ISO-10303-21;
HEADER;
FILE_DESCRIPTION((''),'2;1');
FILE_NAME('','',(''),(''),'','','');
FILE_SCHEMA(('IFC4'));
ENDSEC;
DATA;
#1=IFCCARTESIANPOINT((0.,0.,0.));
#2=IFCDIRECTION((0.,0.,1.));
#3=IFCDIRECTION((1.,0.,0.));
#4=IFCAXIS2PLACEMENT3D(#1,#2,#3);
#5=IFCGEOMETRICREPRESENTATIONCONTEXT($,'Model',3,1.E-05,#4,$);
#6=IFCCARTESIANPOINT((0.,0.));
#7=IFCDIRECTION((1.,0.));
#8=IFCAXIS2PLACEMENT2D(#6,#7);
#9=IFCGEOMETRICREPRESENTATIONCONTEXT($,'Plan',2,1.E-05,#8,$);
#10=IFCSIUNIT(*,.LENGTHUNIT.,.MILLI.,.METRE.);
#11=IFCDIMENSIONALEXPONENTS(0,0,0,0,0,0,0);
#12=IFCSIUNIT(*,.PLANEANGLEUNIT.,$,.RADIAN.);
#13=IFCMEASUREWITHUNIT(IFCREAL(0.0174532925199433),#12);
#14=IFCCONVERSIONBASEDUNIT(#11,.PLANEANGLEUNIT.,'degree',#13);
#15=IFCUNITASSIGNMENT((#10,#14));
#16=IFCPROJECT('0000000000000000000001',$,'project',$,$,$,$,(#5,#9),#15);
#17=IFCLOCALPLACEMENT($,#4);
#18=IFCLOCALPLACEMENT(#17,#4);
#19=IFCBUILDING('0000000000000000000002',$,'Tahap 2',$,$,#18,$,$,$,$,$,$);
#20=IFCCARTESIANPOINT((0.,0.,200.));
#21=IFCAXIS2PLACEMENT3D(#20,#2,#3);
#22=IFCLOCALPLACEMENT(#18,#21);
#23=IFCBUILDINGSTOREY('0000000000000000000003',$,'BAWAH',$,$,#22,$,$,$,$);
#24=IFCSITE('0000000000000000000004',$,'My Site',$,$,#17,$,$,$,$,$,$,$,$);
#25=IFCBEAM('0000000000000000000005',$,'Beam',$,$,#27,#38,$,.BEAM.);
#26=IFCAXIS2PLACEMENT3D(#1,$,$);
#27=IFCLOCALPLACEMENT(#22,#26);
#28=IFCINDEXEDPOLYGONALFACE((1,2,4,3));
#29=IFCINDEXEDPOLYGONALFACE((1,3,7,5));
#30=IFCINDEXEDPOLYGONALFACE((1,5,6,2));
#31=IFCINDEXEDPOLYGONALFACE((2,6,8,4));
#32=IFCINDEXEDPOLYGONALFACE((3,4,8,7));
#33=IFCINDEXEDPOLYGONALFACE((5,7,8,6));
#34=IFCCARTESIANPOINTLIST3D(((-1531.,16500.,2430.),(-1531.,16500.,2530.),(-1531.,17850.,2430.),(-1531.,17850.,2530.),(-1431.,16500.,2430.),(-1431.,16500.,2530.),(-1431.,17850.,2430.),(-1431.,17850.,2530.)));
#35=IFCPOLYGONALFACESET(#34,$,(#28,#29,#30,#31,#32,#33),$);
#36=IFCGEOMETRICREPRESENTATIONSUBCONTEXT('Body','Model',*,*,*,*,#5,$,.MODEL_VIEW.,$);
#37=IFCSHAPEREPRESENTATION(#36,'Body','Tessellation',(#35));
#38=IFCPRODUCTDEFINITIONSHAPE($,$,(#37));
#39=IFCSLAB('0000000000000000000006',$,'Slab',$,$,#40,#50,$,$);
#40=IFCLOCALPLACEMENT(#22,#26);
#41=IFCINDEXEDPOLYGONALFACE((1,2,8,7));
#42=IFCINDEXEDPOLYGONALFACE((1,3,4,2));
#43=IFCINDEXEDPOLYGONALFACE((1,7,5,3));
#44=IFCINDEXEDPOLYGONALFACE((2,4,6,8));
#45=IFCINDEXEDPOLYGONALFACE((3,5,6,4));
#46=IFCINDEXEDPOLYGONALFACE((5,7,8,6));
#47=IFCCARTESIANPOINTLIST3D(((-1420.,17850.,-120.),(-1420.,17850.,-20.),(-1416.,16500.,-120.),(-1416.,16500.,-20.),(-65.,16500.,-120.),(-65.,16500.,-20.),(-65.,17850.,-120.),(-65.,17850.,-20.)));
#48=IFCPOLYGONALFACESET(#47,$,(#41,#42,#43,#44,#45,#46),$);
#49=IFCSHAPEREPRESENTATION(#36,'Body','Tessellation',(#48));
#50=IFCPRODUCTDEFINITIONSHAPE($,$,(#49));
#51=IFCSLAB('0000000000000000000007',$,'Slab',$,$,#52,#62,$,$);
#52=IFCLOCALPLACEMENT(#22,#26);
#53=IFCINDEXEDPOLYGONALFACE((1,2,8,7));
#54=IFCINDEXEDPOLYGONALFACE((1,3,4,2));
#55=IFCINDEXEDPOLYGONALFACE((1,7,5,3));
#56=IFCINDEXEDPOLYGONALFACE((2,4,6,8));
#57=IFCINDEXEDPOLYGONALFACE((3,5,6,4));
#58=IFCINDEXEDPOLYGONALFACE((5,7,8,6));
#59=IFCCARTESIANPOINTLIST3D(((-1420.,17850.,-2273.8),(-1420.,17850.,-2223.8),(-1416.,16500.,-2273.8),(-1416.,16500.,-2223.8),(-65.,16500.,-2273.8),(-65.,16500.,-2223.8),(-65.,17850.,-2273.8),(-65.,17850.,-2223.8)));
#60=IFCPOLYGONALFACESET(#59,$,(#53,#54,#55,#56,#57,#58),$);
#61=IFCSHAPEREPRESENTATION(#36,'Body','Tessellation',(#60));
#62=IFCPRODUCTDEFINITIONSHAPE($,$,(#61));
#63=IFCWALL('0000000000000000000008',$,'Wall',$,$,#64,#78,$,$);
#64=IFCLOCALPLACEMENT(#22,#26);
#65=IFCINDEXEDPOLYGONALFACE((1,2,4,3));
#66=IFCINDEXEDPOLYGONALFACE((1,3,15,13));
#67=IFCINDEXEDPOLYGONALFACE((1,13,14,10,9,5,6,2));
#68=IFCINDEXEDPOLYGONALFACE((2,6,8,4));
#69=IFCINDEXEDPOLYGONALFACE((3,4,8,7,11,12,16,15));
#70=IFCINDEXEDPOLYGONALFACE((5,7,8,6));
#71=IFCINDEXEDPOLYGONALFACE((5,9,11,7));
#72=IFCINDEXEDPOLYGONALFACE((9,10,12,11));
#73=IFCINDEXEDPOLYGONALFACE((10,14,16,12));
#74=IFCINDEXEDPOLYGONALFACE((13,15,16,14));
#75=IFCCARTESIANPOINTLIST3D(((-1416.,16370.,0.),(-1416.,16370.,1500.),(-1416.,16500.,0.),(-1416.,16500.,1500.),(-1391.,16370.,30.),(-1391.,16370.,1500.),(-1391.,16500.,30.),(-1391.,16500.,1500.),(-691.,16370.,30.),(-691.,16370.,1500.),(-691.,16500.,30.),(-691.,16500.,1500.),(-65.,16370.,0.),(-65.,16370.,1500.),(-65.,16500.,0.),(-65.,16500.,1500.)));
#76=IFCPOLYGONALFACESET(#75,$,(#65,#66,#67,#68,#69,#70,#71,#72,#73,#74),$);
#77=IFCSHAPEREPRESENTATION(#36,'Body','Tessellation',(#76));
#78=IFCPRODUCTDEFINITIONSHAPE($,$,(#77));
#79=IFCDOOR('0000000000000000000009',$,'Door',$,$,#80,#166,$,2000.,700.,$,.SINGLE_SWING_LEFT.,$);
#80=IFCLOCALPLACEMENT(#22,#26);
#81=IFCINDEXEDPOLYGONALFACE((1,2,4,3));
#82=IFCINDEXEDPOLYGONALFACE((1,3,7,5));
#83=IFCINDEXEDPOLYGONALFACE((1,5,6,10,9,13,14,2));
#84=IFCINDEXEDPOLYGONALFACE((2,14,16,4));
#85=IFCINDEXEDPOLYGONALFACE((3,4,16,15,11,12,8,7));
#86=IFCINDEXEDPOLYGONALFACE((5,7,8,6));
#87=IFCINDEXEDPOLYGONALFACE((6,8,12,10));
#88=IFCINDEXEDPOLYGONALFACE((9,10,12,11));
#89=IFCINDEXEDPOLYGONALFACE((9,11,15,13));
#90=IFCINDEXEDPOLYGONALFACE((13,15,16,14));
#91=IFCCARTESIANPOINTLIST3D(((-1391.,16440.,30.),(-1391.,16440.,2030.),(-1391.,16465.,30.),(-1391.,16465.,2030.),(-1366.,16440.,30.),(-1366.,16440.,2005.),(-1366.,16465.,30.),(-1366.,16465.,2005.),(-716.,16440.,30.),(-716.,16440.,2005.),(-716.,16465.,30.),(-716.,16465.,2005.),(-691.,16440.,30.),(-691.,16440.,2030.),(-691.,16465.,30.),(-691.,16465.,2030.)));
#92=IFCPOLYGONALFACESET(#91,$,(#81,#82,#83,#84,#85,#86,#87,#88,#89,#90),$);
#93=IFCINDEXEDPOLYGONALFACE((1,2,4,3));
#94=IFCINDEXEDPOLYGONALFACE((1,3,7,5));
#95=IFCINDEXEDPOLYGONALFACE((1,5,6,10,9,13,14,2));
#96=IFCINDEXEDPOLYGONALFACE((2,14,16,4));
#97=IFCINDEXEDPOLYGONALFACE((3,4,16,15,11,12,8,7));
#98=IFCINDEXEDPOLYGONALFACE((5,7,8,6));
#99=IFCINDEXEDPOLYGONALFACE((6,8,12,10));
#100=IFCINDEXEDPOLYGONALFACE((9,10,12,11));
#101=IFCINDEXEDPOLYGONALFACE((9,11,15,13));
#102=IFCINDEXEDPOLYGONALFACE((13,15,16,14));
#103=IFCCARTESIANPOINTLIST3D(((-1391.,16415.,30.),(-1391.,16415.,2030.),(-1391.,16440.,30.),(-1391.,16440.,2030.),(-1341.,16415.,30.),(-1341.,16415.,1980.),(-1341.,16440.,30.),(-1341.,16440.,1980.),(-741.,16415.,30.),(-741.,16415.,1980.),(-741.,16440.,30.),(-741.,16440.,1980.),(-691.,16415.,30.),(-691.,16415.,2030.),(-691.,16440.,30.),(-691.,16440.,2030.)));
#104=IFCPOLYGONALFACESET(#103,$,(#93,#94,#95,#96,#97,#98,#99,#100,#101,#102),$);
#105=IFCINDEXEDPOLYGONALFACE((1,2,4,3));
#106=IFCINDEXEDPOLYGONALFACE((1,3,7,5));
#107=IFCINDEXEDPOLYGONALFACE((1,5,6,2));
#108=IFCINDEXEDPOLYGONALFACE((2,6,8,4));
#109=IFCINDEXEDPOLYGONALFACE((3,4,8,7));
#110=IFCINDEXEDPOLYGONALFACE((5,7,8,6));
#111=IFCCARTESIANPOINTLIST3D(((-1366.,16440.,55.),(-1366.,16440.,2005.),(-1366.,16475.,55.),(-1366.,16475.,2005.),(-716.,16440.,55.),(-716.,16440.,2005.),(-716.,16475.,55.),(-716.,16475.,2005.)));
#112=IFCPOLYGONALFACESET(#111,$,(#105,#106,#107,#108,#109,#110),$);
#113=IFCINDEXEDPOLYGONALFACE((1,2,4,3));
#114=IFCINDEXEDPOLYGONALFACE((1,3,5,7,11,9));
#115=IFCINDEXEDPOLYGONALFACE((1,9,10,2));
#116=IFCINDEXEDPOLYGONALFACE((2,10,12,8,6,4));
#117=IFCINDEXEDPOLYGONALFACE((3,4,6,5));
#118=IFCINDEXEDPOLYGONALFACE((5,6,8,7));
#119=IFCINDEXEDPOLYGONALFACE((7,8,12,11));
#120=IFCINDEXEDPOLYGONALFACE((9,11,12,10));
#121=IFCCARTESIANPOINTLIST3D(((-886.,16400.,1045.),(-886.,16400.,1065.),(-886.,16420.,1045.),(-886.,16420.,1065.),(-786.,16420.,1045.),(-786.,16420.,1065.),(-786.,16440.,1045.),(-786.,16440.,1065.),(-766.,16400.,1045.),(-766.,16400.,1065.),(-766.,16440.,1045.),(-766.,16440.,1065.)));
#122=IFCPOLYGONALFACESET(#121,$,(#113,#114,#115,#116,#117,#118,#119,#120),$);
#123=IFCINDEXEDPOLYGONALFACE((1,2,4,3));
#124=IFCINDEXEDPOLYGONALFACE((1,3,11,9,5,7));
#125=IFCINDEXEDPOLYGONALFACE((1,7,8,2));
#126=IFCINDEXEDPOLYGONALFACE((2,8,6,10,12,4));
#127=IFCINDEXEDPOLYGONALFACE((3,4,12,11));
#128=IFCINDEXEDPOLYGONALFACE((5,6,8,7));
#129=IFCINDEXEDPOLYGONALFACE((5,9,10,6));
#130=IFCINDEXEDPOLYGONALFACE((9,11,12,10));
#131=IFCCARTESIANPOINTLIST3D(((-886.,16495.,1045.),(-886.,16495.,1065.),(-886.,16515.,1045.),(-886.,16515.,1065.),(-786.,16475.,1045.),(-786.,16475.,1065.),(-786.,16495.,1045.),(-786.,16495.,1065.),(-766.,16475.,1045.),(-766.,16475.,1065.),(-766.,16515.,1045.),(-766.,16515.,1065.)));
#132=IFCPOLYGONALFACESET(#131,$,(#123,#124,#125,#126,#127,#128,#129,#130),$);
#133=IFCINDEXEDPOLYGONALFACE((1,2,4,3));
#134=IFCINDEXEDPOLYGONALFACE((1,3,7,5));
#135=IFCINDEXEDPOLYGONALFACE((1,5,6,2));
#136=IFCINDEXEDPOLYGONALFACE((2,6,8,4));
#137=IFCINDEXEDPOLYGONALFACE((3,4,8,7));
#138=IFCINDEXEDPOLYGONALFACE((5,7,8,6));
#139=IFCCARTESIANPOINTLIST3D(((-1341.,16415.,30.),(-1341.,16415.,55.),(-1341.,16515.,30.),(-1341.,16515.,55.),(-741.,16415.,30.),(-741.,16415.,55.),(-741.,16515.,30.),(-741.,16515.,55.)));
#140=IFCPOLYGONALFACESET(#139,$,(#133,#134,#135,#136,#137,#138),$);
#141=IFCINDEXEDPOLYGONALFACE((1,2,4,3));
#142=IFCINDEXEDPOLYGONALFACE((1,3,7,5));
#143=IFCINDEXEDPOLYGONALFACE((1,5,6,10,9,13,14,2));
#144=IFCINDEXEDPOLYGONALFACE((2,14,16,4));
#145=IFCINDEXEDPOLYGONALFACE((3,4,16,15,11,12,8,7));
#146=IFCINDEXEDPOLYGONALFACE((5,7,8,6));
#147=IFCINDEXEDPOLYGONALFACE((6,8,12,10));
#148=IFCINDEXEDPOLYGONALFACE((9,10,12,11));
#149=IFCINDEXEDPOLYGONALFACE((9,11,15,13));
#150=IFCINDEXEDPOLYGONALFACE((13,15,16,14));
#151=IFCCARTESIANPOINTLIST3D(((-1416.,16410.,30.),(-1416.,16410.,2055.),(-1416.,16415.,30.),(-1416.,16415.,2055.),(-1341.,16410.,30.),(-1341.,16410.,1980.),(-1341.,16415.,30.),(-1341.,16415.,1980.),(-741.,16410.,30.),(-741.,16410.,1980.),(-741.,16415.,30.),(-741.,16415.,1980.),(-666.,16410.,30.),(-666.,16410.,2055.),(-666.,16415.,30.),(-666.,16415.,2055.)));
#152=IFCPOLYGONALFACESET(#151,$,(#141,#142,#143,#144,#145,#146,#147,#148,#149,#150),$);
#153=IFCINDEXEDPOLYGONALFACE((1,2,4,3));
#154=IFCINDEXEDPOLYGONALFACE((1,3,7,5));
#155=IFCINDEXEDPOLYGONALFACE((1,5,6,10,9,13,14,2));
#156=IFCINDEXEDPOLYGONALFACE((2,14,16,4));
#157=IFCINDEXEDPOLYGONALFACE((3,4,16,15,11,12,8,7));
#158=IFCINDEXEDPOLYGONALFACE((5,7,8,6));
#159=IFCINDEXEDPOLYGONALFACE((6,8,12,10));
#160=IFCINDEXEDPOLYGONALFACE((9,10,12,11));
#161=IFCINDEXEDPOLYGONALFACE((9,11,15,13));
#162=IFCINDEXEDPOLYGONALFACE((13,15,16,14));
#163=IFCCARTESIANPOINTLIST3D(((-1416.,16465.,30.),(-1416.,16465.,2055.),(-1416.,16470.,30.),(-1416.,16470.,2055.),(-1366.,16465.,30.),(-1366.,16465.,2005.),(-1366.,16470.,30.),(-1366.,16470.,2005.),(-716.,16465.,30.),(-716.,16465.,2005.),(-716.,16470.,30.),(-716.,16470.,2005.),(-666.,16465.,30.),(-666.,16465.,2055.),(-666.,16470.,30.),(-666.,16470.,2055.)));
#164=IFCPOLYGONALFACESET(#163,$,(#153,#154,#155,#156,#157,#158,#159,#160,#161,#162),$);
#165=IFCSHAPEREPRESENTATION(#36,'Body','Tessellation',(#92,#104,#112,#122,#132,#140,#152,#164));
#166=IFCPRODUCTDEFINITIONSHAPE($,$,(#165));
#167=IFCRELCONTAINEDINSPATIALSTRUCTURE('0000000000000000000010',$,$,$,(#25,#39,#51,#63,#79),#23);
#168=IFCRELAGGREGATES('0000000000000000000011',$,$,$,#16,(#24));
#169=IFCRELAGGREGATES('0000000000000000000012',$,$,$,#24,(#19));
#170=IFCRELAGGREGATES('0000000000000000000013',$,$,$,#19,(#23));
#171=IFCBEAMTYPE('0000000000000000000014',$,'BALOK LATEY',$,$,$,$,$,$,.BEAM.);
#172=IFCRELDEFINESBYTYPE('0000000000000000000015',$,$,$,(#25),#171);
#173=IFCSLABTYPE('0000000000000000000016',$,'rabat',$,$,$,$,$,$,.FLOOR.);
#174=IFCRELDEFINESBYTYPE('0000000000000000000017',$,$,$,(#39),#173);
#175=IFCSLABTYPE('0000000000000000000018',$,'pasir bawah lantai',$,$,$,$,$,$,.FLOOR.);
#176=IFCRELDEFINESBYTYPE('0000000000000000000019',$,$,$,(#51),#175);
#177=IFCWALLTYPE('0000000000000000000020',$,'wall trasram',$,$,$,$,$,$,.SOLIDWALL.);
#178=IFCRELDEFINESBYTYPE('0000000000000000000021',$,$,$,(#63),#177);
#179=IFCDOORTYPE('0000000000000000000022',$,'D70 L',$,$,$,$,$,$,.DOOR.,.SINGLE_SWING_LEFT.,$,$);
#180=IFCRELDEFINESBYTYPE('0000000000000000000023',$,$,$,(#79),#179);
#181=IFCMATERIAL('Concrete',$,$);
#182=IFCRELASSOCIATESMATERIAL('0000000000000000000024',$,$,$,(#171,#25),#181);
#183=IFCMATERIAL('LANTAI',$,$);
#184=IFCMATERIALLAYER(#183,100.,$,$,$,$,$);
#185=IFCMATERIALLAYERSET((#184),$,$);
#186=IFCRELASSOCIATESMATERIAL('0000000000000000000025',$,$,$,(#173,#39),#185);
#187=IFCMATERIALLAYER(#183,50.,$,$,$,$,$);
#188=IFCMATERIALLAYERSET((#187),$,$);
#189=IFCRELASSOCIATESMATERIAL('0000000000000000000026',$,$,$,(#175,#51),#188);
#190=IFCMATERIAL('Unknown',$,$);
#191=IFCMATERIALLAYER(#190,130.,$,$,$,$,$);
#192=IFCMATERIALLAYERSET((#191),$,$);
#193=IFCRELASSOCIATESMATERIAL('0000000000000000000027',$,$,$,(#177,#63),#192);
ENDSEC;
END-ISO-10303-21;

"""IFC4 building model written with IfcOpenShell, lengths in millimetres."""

from ifc_helpers import new_model, entity, si_unit, converted_unit, frame, origin_with_axes, origin_2d_with_axis, place, context, subcontext, project, spatial, line, indexed_curve, rectangle, outline, extrude, shape, source, transform, mapped, material, layer, layer_set, layer_usage, material_profile, profile_set, profile_usage, type_object, type_shapes, element, fill, save


model = new_model("IFC4")

# Units and contexts
model_context = context("Model", 3, precision=1e-05, world=origin_with_axes())
plan_context = context("Plan", 2, precision=1e-05, world=origin_2d_with_axis())
body_context_1 = subcontext(model_context, "Body", "Model", "MODEL_VIEW")
body_context_2 = subcontext(plan_context, "Body", "Plan", "PLAN_VIEW")
ifc_project = project(units=[si_unit("LENGTHUNIT", "METRE", prefix="MILLI"), converted_unit("PLANEANGLEUNIT", "degree", entity("IfcReal", 0.0174532925199433), si_unit("PLANEANGLEUNIT", "RADIAN"), dimensions=[0, 0, 0, 0, 0, 0, 0])], contexts=[model_context, plan_context])

# Site, building, storey
site_placement = place(None, origin_with_axes())
site = spatial("IfcSite", under=ifc_project, at=site_placement, Name="My Site")
building_placement = place(site_placement, origin_with_axes())
building = spatial("IfcBuilding", under=site, at=building_placement, Name="Tahap 2")
storey_placement = place(building_placement, frame((0.0, 0.0, 200.0), z_axis=(0.0, 0.0, 1.0), x_axis=(1.0, 0.0, 0.0)))
storey = spatial("IfcBuildingStorey", under=building, at=storey_placement, Name="BAWAH")

# Shared definitions
ifc_material_1 = material(Name="Unknown")

# Shared definitions
ifc_material_2 = material(Name="Concrete")

# Beam
ifc_material_profile_1 = material_profile(ifc_material_2, rectangle(XDim=100.0, YDim=100.0))
ifc_profile_set_1 = profile_set([ifc_material_profile_1])
beam_type_1 = type_object("IfcBeamType", Name="BALOK LATEY", PredefinedType="BEAM", material=ifc_profile_set_1)
ifc_profile_usage_1 = profile_usage(ifc_profile_set_1, cardinal=2)
beam_1_placement = place(storey_placement, frame((-1481.0, 17850.0, 2430.0), z_axis=(0.0, -1.0, -0.000003), x_axis=(1.0, 0.0, 0.0)))
element("IfcBeam", 1, at=beam_1_placement, inside=storey, type_object=beam_type_1, material=ifc_profile_usage_1, Name="Beam", PredefinedType="BEAM", context=body_context_1, shape_type="SweptSolid", body=[
    extrude(rectangle(XDim=100.0, YDim=100.0), frame((0.0, 50.0, 0.0), z_axis=(0.0, 0.0, 1.0), x_axis=(1.0, 0.0, 0.0)), (0.0, 0.0, 1.0), 1350.0),
])

# Slabs
ifc_material_3 = material(Name="LANTAI")
ifc_layer_1 = layer(ifc_material_3, 100.0)
ifc_layer_set_1 = layer_set([ifc_layer_1])
ifc_layer_usage_1 = layer_usage(ifc_layer_set_1, "AXIS3", "NEGATIVE", 0.0)
slab_type_1 = type_object("IfcSlabType", Name="rabat", PredefinedType="FLOOR", material=ifc_layer_set_1)
slab_1_placement = place(storey_placement, frame((-1416.0, 16500.0, -20.0), z_axis=(0.0, 0.0, 1.0), x_axis=(1.0, 0.0, 0.0)))
element("IfcSlab", 2, at=slab_1_placement, inside=storey, type_object=slab_type_1, material=ifc_layer_usage_1, Name="Slab", context=body_context_1, shape_type="SweptSolid", body=[
    extrude(outline(indexed_curve([(0.0, 0.0), (1351.0, 0.0), (1351.0, 1350.0), (-4.0, 1350.0), (0.0, 0.0)])), None, (0.0, 0.0, -1.0), 100.0),
])
ifc_layer_2 = layer(ifc_material_3, 50.0)
ifc_layer_set_2 = layer_set([ifc_layer_2])
ifc_layer_usage_2 = layer_usage(ifc_layer_set_2, "AXIS3", "POSITIVE", -50.0)
slab_type_2 = type_object("IfcSlabType", Name="pasir bawah lantai", PredefinedType="FLOOR", material=ifc_layer_set_2)
slab_2_placement = place(storey_placement, frame((-1416.0, 16500.0, -2223.8), z_axis=(0.0, 0.0, 1.0), x_axis=(1.0, 0.0, 0.0)))
element("IfcSlab", 3, at=slab_2_placement, inside=storey, type_object=slab_type_2, material=ifc_layer_usage_2, Name="Slab", context=body_context_1, shape_type="SweptSolid", body=[
    extrude(outline(indexed_curve([(0.0, 0.0), (1351.0, 0.0), (1351.0, 1350.0), (-4.0, 1350.0), (0.0, 0.0)])), frame((0.0, 0.0, -50.0), z_axis=(0.0, 0.0, 1.0), x_axis=(1.0, 0.0, 0.0)), (0.0, 0.0, 1.0), 50.0),
])

# Wall, opening, door
ifc_layer_3 = layer(ifc_material_1, 130.0)
ifc_layer_set_3 = layer_set([ifc_layer_3])
ifc_layer_usage_3 = layer_usage(ifc_layer_set_3, "AXIS2", "POSITIVE", 0.0)
wall_type = type_object("IfcWallType", Name="wall trasram", PredefinedType="SOLIDWALL", material=ifc_layer_set_3)
wall_1_placement = place(storey_placement, frame((-65.0, 16500.0, 0.0), z_axis=(0.0, 0.0, 1.0), x_axis=(-1.0, 0.0, 0.0)))
wall_1 = element("IfcWall", 4, at=wall_1_placement, inside=storey, type_object=wall_type, material=ifc_layer_usage_3, Name="Wall", context=body_context_1, shape_type="SweptSolid", body=[
    extrude(outline(indexed_curve([(0.0, 0.0), (0.0, 130.0), (1351.0, 130.0), (1351.0, 0.0)], segments=[line(1, 2, 3, 4, 1)])), origin_with_axes(), (0.0, 0.0, 1.0), 1500.0),
])
shared_shape_1 = source(origin_with_axes(), body_context_1, "Body", "SweptSolid", [
    extrude(outline(indexed_curve([(0.0, 0.0), (700.0, 0.0), (700.0, 2000.0), (0.0, 2000.0)], segments=[line(1, 2, 3, 4, 1)])), frame((0.0, -600.0, 0.0), z_axis=(0.0, -1.0, 0.0), x_axis=(1.0, 0.0, 0.0)), (0.0, 0.0, -1.0), 1200.0),
])
opening_placement = place(wall_1_placement, frame((1326.0, 85.0, 30.0), z_axis=(0.0, 0.0, 1.0), x_axis=(-1.0, 0.0, 0.0)))
opening = element("IfcOpeningElement", 5, at=opening_placement, cuts=wall_1, PredefinedType="OPENING", context=body_context_1, shape_type="MappedRepresentation", body=[
    mapped(shared_shape_1, transform((0.0, 0.0, 0.0), x_axis=(1.0, 0.0, 0.0), y_axis=(0.0, 1.0, 0.0), z_axis=(0.0, 0.0, 1.0), scale=1.0)),
])
door_type = type_object("IfcDoorType", Name="D70 L", OperationType="SINGLE_SWING_LEFT", PredefinedType="DOOR")
shared_shape_2 = source(origin_with_axes(), body_context_1, "Body", "SweptSolid", [
    extrude(outline(indexed_curve([(0.0, 0.0), (0.0, 2000.0), (700.0, 2000.0), (700.0, 0.0), (675.0, 0.0), (675.0, 1975.0), (25.0, 1975.0), (25.0, 0.0)], segments=[line(1, 2, 3, 4, 5, 6, 7, 8, 1)])), frame((0.0, 25.0, 0.0), z_axis=(0.0, -1.0, 0.0), x_axis=(1.0, 0.0, 0.0)), (0.0, 0.0, -1.0), 25.0),
    extrude(outline(indexed_curve([(0.0, 0.0), (0.0, 2000.0), (700.0, 2000.0), (700.0, 0.0), (650.0, 0.0), (650.0, 1950.0), (50.0, 1950.0), (50.0, 0.0)], segments=[line(1, 2, 3, 4, 5, 6, 7, 8, 1)])), frame((0.0, 0.0, 0.0), z_axis=(0.0, -1.0, 0.0), x_axis=(1.0, 0.0, 0.0)), (0.0, 0.0, -1.0), 25.0),
    extrude(outline(indexed_curve([(0.0, 0.0), (650.0, 0.0), (650.0, 35.0), (0.0, 35.0)], segments=[line(1, 2, 3, 4, 1)])), frame((25.0, 25.0, 25.0), z_axis=(0.0, 0.0, 1.0), x_axis=(1.0, 0.0, 0.0)), (0.0, 0.0, 1.0), 1950.0),
    extrude(outline(indexed_curve([(0.0, 0.0), (0.0, -40.0), (-120.0, -40.0), (-120.0, -20.0), (-20.0, -20.0), (-20.0, 0.0)], segments=[line(1, 2, 3, 4, 5, 6, 1)])), frame((625.0, 25.0, 1015.0), z_axis=(0.0, 0.0, 1.0), x_axis=(1.0, 0.0, 0.0)), (0.0, 0.0, 1.0), 20.0),
    extrude(outline(indexed_curve([(0.0, 0.0), (0.0, 40.0), (-120.0, 40.0), (-120.0, 20.0), (-20.0, 20.0), (-20.0, 0.0)], segments=[line(1, 2, 3, 4, 5, 6, 1)])), frame((625.0, 60.0, 1015.0), z_axis=(0.0, 0.0, 1.0), x_axis=(1.0, 0.0, 0.0)), (0.0, 0.0, 1.0), 20.0),
    extrude(outline(indexed_curve([(0.0, 0.0), (600.0, 0.0), (600.0, 100.0), (0.0, 100.0)], segments=[line(1, 2, 3, 4, 1)])), frame((50.0, 0.0, 0.0), z_axis=(0.0, 0.0, 1.0), x_axis=(1.0, 0.0, 0.0)), (0.0, 0.0, 1.0), 25.0),
    extrude(outline(indexed_curve([(0.0, 0.0), (0.0, 2025.0), (750.0, 2025.0), (750.0, 0.0), (675.0, 0.0), (675.0, 1950.0), (75.0, 1950.0), (75.0, 0.0)], segments=[line(1, 2, 3, 4, 5, 6, 7, 8, 1)])), frame((-25.0, -5.0, 0.0), z_axis=(0.0, -1.0, 0.0), x_axis=(1.0, 0.0, 0.0)), (0.0, 0.0, -1.0), 5.0),
    extrude(outline(indexed_curve([(0.0, 0.0), (0.0, 2025.0), (750.0, 2025.0), (750.0, 0.0), (700.0, 0.0), (700.0, 1975.0), (50.0, 1975.0), (50.0, 0.0)], segments=[line(1, 2, 3, 4, 5, 6, 7, 8, 1)])), frame((-25.0, 50.0, 0.0), z_axis=(0.0, -1.0, 0.0), x_axis=(1.0, 0.0, 0.0)), (0.0, 0.0, -1.0), 5.0),
])
shared_shape_3 = source(origin_with_axes(), body_context_2, "Body", "Curve2D", [
    entity("IfcIndexedPolyCurve", entity("IfcCartesianPointList2D", [[0.0, 0.0], [0.0, 50.0], [25.0, 50.0], [25.0, 25.0], [50.0, 25.0], [50.0, 0.0]]), [entity("IfcLineIndex", [1, 2, 3, 4, 5, 6, 1])]),
    entity("IfcIndexedPolyCurve", entity("IfcCartesianPointList2D", [[700.0, 0.0], [700.0, 50.0], [675.0, 50.0], [675.0, 25.0], [650.0, 25.0], [650.0, 0.0]]), [entity("IfcLineIndex", [1, 2, 3, 4, 5, 6, 1])]),
    entity("IfcTrimmedCurve", entity("IfcEllipse", entity("IfcAxis2Placement2D", entity("IfcCartesianPoint", [60.0, 50.0]), entity("IfcDirection", [1.0, 0.0])), 615.0, 650.0), [entity("IfcCartesianPoint", [675.0, 50.0])], [entity("IfcCartesianPoint", [60.0, 700.0])], True, "CARTESIAN"),
    entity("IfcIndexedPolyCurve", entity("IfcCartesianPointList2D", [[25.0, 50.0], [60.0, 50.0], [60.0, 700.0], [25.0, 700.0]]), [entity("IfcLineIndex", [1, 2, 3, 4, 1])]),
])
type_shapes(door_type, [shared_shape_2, shared_shape_3])
door_placement = place(opening_placement, frame((0.0, 0.0, 0.0), z_axis=(0.0, 0.0, 1.0), x_axis=(1.0, 0.0, 0.0)))
door = element("IfcDoor", 6, at=door_placement, inside=storey, type_object=door_type, Name="Door", OperationType="SINGLE_SWING_LEFT", OverallHeight=2000.0, OverallWidth=700.0, shapes=[
    shape(body_context_1, "Body", "MappedRepresentation", [mapped(shared_shape_2, transform((0.0, 0.0, 0.0), x_axis=(1.0, 0.0, 0.0), y_axis=(0.0, 1.0, 0.0), z_axis=(0.0, 0.0, 1.0), scale=1.0))]),
    shape(body_context_2, "Body", "MappedRepresentation", [mapped(shared_shape_3, transform((0.0, 0.0, 0.0), x_axis=(1.0, 0.0, 0.0), y_axis=(0.0, 1.0, 0.0), z_axis=(0.0, 0.0, 1.0), scale=1.0))]),
])
fill(opening, door)

save(model, "model.ifc")
